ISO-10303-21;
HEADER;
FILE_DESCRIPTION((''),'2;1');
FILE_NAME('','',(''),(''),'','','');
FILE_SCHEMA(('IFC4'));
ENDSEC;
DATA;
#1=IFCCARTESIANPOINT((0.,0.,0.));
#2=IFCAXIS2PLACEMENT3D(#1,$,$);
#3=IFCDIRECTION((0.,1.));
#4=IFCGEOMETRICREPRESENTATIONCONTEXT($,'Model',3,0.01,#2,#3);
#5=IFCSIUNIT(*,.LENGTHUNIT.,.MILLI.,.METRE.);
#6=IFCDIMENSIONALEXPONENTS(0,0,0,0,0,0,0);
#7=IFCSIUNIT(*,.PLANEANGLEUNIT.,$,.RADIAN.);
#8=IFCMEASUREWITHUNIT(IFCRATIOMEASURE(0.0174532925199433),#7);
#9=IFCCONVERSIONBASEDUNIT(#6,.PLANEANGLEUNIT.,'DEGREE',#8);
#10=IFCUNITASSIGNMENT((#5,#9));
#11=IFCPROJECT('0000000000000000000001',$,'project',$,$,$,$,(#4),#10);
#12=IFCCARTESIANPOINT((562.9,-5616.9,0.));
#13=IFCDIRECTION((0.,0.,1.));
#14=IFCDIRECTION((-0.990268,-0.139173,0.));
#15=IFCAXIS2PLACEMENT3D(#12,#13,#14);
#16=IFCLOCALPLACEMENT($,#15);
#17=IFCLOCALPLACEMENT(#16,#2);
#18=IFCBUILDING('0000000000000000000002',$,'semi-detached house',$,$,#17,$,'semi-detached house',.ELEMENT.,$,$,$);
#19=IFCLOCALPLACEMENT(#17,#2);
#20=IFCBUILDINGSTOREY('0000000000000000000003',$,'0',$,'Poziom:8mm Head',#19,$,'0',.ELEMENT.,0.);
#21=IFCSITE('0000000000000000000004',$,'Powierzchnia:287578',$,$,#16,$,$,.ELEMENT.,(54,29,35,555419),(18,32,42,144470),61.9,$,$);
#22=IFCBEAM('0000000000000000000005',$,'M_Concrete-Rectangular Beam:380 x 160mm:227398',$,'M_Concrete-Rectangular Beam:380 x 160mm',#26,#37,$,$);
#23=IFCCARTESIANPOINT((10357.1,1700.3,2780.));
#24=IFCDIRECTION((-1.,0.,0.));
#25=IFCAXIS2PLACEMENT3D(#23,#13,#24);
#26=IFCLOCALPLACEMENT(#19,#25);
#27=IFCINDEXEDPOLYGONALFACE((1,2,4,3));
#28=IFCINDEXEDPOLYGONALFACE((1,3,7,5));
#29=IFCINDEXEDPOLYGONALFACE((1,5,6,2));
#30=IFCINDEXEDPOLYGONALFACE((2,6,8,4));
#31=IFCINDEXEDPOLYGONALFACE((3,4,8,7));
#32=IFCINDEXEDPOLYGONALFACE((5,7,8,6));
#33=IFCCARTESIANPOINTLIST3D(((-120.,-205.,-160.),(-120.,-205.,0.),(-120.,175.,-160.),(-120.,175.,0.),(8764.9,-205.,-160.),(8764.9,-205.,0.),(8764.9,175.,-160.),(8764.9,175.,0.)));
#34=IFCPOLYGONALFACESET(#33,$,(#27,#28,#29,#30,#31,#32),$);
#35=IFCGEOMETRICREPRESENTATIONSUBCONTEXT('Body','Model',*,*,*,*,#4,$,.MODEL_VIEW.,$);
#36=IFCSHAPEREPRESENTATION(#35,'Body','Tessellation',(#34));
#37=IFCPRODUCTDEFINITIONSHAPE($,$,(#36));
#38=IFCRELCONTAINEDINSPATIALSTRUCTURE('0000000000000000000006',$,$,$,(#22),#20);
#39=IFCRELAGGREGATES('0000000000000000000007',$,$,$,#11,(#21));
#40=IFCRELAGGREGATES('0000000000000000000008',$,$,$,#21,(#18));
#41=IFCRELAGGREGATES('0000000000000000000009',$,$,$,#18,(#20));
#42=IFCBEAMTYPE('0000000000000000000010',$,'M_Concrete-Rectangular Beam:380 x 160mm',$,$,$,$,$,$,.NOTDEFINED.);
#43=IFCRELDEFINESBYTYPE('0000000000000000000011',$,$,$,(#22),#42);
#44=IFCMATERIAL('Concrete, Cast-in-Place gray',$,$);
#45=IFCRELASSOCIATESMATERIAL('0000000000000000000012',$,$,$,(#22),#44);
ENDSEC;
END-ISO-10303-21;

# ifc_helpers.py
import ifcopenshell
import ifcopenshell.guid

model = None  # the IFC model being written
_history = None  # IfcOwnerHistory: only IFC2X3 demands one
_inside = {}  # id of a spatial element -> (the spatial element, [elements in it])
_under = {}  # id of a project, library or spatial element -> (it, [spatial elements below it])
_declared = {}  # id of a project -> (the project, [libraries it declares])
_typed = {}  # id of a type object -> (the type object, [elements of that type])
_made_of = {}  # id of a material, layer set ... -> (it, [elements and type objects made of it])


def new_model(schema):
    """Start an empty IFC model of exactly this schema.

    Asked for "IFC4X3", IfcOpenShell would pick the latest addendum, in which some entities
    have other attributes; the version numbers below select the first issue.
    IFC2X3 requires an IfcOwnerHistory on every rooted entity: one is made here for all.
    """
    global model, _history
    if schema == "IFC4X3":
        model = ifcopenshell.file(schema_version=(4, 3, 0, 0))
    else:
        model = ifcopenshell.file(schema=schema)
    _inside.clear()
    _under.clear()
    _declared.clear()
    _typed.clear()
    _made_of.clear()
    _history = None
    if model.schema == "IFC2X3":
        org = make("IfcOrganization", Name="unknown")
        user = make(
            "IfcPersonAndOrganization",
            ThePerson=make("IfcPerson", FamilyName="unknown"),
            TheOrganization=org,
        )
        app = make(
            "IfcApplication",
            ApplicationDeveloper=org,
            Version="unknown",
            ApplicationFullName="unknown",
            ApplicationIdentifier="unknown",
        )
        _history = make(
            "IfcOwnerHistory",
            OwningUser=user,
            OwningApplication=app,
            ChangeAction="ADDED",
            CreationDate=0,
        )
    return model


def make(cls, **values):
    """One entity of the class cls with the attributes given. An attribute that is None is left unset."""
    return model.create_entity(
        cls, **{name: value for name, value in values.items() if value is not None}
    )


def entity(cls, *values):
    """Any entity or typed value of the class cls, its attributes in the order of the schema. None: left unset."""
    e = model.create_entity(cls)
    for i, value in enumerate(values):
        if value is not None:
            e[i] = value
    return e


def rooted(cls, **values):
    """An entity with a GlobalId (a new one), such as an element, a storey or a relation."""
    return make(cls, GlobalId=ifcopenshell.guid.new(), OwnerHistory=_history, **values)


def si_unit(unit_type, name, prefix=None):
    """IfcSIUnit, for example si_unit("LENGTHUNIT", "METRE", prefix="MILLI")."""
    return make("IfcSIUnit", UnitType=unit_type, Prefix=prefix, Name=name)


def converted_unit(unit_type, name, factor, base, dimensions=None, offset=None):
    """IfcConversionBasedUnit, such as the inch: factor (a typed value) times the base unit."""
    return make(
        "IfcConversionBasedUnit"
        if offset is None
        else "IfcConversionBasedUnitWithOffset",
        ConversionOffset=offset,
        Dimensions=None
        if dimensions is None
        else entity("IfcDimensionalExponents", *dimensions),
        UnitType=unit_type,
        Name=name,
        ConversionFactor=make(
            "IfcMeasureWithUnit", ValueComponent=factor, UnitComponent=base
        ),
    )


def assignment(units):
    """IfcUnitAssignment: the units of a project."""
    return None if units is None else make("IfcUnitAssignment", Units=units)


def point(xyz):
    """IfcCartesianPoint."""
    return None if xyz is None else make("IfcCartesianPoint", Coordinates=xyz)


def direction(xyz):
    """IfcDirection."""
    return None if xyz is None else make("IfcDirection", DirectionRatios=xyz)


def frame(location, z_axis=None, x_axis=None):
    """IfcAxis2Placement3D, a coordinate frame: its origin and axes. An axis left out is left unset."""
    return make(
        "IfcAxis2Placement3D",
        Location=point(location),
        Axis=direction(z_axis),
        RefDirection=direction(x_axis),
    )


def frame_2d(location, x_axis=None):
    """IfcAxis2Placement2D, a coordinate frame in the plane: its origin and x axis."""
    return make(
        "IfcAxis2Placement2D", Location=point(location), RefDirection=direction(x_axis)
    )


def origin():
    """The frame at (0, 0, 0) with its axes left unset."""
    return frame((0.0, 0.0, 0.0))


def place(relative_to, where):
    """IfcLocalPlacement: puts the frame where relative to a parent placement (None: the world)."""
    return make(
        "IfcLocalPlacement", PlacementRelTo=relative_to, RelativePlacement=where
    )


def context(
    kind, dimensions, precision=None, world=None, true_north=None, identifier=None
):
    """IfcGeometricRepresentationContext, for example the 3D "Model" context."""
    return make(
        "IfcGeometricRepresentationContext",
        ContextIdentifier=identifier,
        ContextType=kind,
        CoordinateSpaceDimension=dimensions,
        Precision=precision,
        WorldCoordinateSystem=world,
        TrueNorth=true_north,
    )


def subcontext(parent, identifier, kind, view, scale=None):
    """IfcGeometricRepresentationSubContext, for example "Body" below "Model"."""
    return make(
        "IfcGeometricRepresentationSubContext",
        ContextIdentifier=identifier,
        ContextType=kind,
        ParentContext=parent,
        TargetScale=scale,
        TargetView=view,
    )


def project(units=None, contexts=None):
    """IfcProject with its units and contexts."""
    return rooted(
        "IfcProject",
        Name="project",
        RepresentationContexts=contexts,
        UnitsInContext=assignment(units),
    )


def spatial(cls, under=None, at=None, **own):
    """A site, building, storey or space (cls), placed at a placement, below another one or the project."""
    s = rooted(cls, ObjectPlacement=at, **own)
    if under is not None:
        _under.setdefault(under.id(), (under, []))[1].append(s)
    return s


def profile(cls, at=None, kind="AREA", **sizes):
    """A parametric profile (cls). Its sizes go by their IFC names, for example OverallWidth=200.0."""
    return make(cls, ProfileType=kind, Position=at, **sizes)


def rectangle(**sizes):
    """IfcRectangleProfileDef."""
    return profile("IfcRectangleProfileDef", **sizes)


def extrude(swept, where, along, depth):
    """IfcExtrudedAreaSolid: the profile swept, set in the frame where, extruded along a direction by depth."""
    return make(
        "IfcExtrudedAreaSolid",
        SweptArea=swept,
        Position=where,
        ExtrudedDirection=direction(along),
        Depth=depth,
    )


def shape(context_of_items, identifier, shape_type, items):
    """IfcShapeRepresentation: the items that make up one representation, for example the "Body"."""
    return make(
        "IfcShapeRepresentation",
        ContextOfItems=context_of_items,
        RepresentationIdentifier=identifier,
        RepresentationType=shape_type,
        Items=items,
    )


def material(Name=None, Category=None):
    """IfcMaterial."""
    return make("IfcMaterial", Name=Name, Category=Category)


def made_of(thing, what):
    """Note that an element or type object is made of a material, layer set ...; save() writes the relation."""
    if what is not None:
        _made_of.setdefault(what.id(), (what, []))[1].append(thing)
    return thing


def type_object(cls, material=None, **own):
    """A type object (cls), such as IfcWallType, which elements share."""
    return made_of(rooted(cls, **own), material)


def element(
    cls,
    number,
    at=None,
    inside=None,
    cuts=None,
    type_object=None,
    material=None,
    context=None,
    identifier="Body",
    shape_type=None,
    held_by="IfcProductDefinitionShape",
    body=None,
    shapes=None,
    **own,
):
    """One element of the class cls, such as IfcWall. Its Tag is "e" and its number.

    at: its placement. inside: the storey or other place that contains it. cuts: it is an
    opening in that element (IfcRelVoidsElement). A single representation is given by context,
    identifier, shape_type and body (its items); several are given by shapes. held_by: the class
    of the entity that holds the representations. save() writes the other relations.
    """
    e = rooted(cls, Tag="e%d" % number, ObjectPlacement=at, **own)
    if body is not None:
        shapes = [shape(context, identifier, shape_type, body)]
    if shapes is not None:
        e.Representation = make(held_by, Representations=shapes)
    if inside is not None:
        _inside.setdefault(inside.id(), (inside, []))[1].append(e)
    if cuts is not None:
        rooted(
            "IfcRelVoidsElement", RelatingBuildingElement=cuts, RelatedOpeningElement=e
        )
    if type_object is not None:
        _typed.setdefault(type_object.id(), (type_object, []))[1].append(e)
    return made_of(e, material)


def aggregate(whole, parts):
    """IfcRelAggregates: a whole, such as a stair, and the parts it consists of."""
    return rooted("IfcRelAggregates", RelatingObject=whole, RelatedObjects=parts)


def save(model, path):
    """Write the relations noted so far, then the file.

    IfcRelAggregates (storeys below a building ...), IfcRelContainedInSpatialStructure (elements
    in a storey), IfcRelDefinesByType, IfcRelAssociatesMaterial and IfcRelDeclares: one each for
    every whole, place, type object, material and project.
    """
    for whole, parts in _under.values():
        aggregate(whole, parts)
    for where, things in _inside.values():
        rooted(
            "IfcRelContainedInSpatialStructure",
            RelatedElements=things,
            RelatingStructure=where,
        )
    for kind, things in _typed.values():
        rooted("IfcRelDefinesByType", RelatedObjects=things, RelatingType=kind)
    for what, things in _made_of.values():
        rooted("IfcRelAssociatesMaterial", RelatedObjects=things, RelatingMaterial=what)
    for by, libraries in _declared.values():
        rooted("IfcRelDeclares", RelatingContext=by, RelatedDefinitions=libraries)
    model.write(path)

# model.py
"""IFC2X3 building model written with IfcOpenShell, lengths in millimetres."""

from ifc_helpers import new_model, entity, si_unit, converted_unit, direction, frame, frame_2d, origin, place, context, subcontext, project, spatial, rectangle, extrude, material, type_object, element, save


model = new_model("IFC2X3")

# Units and contexts
model_context = context("Model", 3, precision=0.01, world=origin(), true_north=direction((0.0, 1.0)))
body_context = subcontext(model_context, "Body", "Model", "MODEL_VIEW")
ifc_project = project(units=[si_unit("LENGTHUNIT", "METRE", prefix="MILLI"), converted_unit("PLANEANGLEUNIT", "DEGREE", entity("IfcRatioMeasure", 0.0174532925199433), si_unit("PLANEANGLEUNIT", "RADIAN"), dimensions=[0, 0, 0, 0, 0, 0, 0])], contexts=[model_context])

# Site, building, storey
site_placement = place(None, frame((562.9, -5616.9, 0.0), z_axis=(0.0, 0.0, 1.0), x_axis=(-0.990268, -0.139173, 0.0)))
site = spatial("IfcSite", under=ifc_project, at=site_placement, Name="Powierzchnia:287578", CompositionType="ELEMENT", RefLatitude=(54, 29, 35, 555419), RefLongitude=(18, 32, 42, 144470), RefElevation=61.9)
building_placement = place(site_placement, origin())
building = spatial("IfcBuilding", under=site, at=building_placement, Name="semi-detached house", LongName="semi-detached house", CompositionType="ELEMENT")
storey_placement = place(building_placement, origin())
storey = spatial("IfcBuildingStorey", under=building, at=storey_placement, Name="0", ObjectType="Poziom:8mm Head", LongName="0", CompositionType="ELEMENT", Elevation=0.0)

# Beam
ifc_material_1 = material(Name="Concrete, Cast-in-Place gray")
beam_type_1 = type_object("IfcBeamType", Name="M_Concrete-Rectangular Beam:380 x 160mm", PredefinedType="NOTDEFINED")
beam_1_placement = place(storey_placement, frame((10357.1, 1700.3, 2780.0), z_axis=(0.0, 0.0, 1.0), x_axis=(-1.0, 0.0, 0.0)))
element("IfcBeam", 1, at=beam_1_placement, inside=storey, type_object=beam_type_1, material=ifc_material_1, Name="M_Concrete-Rectangular Beam:380 x 160mm:227398", ObjectType="M_Concrete-Rectangular Beam:380 x 160mm", context=body_context, shape_type="SweptSolid", body=[
    extrude(rectangle(XDim=160.0, YDim=380.0, at=frame_2d((0.0, 0.0), x_axis=(1.0, 0.0))), frame((-120.0, -15.0, -80.0), z_axis=(1.0, 0.0, 0.0), x_axis=(0.0, 0.0, -1.0)), (0.0, 0.0, 1.0), 8884.9),
])

save(model, "model.ifc")
